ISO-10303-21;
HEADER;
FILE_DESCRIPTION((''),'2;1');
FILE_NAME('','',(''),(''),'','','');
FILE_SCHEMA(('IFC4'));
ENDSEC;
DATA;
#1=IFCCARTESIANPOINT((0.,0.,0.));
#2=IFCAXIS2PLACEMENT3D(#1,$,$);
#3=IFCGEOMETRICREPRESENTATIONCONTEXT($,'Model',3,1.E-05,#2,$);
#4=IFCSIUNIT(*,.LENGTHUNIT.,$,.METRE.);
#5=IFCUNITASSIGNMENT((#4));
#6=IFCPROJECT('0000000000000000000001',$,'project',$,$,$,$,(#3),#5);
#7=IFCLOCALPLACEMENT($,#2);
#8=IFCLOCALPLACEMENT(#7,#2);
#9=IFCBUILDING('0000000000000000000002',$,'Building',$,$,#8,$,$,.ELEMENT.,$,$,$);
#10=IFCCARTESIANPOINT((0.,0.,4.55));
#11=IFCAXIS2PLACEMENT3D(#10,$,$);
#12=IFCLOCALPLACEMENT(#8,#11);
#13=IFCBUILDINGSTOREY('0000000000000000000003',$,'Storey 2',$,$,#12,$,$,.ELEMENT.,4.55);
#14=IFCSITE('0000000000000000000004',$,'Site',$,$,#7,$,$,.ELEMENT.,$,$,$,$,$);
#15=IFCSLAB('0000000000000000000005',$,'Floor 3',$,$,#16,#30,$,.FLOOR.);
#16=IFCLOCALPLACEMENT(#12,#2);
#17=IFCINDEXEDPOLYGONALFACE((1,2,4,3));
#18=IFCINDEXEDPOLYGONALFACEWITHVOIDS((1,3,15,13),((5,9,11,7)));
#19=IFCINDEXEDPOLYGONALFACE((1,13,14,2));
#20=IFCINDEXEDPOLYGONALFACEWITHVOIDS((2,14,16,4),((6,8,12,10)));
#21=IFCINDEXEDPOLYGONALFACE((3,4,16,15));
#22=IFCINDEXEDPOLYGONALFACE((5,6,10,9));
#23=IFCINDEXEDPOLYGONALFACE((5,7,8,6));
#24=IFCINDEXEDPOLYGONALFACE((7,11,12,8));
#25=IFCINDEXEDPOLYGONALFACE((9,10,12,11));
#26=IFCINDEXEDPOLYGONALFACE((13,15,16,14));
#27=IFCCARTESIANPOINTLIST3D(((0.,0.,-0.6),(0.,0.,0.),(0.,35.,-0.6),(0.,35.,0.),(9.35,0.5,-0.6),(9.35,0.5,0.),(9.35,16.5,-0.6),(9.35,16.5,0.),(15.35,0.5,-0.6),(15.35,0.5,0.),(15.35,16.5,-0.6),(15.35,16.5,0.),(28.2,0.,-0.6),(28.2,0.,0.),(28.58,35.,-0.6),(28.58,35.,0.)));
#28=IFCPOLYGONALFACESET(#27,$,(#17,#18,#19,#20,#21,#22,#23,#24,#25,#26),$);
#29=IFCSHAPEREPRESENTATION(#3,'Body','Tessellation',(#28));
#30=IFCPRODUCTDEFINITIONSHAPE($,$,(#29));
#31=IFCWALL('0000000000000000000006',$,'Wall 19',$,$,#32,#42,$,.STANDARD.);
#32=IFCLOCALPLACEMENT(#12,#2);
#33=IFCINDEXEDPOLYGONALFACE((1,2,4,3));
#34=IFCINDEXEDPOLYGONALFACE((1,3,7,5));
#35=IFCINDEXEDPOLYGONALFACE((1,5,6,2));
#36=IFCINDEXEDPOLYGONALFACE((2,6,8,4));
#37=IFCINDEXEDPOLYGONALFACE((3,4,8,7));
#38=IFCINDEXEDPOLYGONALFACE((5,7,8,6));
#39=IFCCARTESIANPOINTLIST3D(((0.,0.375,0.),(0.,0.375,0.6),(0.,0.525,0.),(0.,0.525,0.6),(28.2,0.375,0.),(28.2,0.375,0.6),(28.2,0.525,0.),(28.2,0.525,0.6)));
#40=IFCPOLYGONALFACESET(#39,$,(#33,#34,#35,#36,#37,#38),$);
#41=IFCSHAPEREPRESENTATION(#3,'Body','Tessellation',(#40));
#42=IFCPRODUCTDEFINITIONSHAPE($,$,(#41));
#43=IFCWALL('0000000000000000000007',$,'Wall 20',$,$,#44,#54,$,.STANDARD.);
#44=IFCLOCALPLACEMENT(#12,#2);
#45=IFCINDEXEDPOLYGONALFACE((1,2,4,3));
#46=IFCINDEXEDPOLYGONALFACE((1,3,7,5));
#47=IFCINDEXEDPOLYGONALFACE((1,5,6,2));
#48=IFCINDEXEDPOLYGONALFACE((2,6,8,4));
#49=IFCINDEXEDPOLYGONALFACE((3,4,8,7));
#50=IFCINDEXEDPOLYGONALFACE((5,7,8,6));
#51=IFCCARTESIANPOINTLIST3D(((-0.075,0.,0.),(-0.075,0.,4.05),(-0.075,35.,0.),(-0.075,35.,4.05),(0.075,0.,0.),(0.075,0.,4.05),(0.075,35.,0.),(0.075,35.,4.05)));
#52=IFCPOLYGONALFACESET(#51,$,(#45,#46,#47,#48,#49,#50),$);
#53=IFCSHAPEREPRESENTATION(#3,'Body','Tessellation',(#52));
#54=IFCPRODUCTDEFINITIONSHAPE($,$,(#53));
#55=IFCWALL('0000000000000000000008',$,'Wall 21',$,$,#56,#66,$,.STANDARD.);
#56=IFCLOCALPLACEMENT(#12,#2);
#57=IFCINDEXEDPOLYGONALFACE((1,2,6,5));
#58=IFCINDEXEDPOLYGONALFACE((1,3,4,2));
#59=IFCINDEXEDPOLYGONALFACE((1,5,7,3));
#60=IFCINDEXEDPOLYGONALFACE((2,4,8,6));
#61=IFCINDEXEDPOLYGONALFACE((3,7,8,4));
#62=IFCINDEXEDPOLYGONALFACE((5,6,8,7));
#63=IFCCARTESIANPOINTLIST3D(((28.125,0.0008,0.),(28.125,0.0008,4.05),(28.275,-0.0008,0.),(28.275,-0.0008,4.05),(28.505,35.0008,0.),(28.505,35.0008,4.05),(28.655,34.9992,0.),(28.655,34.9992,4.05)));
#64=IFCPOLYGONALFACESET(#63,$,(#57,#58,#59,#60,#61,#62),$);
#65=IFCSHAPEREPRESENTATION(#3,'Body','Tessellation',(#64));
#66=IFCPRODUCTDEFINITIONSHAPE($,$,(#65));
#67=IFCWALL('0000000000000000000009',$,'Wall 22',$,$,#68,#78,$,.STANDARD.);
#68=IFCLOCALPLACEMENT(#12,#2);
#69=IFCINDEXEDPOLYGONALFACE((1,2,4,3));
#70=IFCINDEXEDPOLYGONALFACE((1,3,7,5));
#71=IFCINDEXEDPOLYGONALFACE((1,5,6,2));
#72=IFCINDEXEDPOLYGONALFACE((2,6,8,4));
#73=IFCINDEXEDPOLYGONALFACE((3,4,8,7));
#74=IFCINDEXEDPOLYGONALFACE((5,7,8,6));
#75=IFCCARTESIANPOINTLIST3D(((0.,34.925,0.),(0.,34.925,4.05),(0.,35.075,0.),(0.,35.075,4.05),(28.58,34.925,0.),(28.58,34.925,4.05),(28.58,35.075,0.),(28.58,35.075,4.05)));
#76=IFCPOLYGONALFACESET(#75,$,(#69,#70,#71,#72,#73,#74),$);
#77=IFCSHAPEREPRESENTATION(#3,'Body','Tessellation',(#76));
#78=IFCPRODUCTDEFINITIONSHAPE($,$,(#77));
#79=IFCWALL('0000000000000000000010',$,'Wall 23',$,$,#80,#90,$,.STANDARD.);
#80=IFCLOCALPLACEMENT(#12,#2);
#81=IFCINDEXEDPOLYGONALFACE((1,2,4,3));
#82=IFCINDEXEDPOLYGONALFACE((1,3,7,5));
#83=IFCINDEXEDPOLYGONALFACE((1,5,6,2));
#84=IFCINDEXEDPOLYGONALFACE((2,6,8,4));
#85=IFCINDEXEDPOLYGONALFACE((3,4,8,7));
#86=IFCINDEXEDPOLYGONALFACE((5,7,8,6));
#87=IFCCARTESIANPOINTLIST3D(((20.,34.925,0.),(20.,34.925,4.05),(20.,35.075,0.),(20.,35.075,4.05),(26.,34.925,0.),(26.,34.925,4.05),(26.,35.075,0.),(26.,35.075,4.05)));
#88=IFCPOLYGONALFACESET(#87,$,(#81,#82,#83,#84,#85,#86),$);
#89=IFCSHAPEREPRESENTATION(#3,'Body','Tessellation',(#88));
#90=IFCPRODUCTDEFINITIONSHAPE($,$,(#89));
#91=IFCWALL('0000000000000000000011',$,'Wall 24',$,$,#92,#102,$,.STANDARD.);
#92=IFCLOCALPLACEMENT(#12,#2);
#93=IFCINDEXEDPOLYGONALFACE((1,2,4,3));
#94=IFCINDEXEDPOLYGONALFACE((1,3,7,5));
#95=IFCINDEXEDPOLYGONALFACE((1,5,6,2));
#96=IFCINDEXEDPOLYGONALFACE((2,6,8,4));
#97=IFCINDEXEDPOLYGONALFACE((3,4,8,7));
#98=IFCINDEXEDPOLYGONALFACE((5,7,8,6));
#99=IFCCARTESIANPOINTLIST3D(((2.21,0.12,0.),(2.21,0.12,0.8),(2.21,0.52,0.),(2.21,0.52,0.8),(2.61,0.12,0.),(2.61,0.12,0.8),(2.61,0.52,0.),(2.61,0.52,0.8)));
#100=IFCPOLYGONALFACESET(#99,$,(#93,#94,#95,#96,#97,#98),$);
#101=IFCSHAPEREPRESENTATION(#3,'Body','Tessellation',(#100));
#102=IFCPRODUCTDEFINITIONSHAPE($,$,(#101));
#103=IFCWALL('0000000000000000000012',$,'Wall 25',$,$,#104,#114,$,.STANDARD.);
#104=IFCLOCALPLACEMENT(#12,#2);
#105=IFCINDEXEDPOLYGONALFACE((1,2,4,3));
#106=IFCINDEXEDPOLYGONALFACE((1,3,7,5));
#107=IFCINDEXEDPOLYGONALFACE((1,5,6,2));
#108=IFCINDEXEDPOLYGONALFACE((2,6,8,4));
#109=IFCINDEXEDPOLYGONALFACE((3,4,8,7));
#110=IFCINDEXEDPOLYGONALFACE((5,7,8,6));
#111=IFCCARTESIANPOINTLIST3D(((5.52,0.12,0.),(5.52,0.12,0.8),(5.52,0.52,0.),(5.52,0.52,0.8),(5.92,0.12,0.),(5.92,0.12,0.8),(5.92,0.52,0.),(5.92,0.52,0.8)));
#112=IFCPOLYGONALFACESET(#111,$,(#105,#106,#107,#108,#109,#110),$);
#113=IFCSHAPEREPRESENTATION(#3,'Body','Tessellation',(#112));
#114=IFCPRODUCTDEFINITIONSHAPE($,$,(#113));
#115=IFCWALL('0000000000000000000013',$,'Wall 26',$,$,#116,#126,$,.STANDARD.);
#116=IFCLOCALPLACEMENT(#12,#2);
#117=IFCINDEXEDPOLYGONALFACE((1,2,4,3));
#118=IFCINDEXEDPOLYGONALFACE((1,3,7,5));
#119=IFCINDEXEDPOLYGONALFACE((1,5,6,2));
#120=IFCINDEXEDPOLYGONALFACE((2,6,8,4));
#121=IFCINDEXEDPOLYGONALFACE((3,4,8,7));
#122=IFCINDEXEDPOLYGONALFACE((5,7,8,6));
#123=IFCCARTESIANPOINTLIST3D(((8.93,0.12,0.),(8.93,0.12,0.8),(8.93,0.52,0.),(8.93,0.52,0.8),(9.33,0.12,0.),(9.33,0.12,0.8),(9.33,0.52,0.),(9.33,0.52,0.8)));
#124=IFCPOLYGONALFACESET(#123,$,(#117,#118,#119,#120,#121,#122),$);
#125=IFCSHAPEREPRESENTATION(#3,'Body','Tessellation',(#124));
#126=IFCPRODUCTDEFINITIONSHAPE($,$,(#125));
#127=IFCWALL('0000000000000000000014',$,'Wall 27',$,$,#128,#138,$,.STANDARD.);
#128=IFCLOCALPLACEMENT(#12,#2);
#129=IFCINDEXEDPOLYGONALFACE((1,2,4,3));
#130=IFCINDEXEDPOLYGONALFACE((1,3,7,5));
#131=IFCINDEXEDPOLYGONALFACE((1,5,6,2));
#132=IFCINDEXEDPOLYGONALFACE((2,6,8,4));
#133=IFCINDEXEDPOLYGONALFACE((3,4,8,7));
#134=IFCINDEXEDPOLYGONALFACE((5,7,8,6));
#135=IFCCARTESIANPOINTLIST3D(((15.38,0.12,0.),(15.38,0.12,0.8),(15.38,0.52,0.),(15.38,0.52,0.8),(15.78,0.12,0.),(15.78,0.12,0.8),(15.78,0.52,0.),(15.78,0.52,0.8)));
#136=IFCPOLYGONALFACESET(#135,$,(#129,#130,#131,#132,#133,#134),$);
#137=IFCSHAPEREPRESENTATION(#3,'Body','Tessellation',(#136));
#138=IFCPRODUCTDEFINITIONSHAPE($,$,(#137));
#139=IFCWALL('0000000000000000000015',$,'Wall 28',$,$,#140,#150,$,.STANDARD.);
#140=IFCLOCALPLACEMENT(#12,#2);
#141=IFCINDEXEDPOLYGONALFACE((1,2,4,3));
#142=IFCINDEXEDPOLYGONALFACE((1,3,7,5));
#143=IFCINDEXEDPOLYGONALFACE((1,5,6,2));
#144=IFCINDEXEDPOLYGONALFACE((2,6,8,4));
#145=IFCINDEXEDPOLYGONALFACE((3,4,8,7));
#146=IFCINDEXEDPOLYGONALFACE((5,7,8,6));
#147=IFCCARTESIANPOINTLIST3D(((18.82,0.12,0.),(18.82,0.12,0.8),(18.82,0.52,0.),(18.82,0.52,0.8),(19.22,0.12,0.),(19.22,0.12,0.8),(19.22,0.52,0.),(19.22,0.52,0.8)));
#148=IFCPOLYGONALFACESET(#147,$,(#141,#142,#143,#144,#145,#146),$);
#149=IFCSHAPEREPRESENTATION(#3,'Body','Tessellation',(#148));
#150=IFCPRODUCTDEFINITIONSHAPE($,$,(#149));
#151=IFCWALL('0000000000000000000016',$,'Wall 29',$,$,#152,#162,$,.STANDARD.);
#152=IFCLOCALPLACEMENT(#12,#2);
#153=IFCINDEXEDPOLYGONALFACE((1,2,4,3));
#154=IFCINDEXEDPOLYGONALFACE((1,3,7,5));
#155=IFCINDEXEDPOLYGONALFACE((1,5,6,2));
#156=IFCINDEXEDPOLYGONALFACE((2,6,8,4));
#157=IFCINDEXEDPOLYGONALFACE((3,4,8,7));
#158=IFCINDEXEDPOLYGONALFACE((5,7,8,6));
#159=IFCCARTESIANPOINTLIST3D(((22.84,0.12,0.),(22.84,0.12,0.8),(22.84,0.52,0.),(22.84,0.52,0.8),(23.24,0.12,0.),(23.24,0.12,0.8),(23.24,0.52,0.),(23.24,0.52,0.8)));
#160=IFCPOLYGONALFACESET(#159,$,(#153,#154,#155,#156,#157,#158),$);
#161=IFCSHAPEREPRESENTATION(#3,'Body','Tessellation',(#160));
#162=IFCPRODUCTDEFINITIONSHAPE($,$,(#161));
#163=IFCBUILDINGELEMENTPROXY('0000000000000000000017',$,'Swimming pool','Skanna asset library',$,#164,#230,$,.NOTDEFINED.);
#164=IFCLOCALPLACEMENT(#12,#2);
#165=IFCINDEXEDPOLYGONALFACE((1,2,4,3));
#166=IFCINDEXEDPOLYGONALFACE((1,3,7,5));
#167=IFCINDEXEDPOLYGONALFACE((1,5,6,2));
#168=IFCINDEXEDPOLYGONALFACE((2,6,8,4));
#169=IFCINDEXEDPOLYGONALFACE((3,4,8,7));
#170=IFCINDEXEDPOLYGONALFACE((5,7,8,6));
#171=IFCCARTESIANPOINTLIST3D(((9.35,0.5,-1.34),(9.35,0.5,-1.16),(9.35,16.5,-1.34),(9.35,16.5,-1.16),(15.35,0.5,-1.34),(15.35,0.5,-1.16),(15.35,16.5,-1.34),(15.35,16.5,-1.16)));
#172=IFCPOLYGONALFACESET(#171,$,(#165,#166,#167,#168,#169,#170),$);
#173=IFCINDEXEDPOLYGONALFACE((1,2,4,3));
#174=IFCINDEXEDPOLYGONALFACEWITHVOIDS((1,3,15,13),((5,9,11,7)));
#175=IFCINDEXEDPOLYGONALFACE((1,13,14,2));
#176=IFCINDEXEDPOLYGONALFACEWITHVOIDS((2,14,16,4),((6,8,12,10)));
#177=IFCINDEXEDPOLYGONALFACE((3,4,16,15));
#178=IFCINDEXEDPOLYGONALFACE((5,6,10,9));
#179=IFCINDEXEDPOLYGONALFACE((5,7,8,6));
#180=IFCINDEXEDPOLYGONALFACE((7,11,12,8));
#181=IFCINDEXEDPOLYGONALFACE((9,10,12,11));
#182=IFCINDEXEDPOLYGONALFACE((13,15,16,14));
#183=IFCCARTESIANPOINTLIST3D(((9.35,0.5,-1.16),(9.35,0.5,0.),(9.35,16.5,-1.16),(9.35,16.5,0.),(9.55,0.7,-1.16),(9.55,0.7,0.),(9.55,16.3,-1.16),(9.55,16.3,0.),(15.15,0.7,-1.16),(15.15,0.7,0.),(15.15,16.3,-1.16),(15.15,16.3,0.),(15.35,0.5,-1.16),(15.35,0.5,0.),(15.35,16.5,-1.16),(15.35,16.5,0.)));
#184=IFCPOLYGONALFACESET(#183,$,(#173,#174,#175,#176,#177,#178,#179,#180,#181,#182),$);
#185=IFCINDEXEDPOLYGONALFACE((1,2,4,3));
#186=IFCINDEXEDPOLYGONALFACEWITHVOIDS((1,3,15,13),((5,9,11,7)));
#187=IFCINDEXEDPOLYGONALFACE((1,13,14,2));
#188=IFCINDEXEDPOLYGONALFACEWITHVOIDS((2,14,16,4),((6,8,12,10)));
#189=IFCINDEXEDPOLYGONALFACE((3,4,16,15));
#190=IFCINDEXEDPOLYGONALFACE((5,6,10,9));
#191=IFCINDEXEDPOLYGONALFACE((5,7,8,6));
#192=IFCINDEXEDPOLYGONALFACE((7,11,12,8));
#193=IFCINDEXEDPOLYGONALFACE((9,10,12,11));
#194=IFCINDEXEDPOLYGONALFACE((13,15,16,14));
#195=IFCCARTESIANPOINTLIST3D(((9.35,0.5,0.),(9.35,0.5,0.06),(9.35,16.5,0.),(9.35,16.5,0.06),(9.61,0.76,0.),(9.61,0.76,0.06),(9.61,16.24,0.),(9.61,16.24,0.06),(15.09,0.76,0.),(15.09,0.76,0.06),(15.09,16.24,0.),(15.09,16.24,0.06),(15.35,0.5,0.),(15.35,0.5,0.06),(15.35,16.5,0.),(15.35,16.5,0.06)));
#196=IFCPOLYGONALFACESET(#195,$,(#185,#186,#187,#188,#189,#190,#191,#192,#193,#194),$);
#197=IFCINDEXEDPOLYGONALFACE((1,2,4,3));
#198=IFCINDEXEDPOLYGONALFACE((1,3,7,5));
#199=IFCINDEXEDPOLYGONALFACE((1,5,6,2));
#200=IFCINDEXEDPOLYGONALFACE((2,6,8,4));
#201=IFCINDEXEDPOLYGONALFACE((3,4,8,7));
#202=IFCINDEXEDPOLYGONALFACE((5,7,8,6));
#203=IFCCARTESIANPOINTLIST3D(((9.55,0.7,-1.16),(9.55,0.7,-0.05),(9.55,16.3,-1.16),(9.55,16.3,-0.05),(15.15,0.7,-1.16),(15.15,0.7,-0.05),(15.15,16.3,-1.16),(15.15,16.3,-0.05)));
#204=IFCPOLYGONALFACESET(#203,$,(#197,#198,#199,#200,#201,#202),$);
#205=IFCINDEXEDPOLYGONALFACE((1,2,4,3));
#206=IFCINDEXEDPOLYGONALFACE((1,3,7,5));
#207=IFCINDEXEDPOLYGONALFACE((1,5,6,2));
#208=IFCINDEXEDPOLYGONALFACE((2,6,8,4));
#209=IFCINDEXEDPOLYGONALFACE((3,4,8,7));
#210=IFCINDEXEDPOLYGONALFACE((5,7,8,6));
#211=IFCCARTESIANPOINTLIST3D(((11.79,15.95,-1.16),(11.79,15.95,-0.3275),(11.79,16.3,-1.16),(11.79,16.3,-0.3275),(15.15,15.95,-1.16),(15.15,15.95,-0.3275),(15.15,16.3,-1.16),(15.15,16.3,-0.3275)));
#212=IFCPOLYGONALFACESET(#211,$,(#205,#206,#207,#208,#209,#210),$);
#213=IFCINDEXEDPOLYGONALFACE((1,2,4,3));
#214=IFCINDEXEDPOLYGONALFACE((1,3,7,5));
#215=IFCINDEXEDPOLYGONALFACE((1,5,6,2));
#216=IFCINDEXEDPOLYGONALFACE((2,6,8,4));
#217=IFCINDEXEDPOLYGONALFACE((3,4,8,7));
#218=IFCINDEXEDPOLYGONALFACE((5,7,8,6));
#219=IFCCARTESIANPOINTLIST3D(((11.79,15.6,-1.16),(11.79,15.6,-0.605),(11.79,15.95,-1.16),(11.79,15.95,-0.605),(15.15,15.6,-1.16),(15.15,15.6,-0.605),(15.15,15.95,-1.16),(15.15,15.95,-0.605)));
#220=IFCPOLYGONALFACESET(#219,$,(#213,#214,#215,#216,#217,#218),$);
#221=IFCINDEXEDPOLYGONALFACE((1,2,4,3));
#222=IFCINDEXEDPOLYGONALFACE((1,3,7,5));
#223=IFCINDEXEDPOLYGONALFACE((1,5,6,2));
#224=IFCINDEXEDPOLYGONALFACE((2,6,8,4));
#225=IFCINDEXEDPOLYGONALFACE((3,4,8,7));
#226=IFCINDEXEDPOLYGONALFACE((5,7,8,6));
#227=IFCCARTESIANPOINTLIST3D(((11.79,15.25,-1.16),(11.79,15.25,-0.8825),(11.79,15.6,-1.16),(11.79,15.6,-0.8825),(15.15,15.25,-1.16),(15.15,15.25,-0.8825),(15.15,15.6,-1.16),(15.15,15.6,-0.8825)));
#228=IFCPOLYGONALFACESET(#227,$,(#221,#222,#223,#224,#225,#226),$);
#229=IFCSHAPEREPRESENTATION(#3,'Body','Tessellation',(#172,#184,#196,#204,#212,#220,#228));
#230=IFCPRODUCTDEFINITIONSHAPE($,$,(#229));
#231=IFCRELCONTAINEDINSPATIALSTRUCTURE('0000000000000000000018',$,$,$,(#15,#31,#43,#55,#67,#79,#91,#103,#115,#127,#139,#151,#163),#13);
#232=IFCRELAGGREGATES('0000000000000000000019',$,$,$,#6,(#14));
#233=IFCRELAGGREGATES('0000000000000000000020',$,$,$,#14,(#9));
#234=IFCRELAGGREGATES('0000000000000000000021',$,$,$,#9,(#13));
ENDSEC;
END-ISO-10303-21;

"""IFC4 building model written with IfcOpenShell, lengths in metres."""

from ifc_helpers import new_model, si_unit, frame, frame_2d, origin, origin_2d, place, context, project, spatial, polyline, rectangle, outline, extrude, element, save


model = new_model("IFC4")

# Units and contexts
model_context = context("Model", 3, precision=1e-05, world=origin())
ifc_project = project(units=[si_unit("LENGTHUNIT", "METRE")], contexts=[model_context])

# Site, building, storey
site_placement = place(None, origin())
site = spatial("IfcSite", under=ifc_project, at=site_placement, Name="Site", CompositionType="ELEMENT")
building_placement = place(site_placement, origin())
building = spatial("IfcBuilding", under=site, at=building_placement, Name="Building", CompositionType="ELEMENT")
storey_placement = place(building_placement, frame((0.0, 0.0, 4.55)))
storey = spatial("IfcBuildingStorey", under=building, at=storey_placement, Name="Storey 2", CompositionType="ELEMENT", Elevation=4.55)

# Slab
slab_placement = place(storey_placement, frame((0.0, 0.0, -0.6), z_axis=(0.0, 0.0, 1.0), x_axis=(1.0, 0.0, 0.0)))
element("IfcSlab", 1, at=slab_placement, inside=storey, Name="Floor 3", PredefinedType="FLOOR", context=model_context, shape_type="SweptSolid", body=[
    extrude(outline(polyline([(0.0, 0.0), (0.0, 35.0), (28.58, 35.0), (28.2, 0.0), (0.0, 0.0)]), holes=[polyline([(9.35, 0.5), (15.35, 0.5), (15.35, 16.5), (9.35, 16.5), (9.35, 0.5)])]), origin(), (0.0, 0.0, 1.0), 0.6),
])

# Walls
wall_1_placement = place(storey_placement, frame((0.0, 0.45, 0.0), z_axis=(0.0, 0.0, 1.0), x_axis=(1.0, 0.0, 0.0)))
element("IfcWall", 2, at=wall_1_placement, inside=storey, Name="Wall 19", PredefinedType="STANDARD", context=model_context, shape_type="SweptSolid", body=[
    extrude(rectangle(XDim=28.2, YDim=0.15, at=frame_2d((14.1, 0.0))), origin(), (0.0, 0.0, 1.0), 0.6),
])
wall_2_placement = place(storey_placement, frame((0.0, 0.0, 0.0), z_axis=(0.0, 0.0, 1.0), x_axis=(0.0, 1.0, 0.0)))
element("IfcWall", 3, at=wall_2_placement, inside=storey, Name="Wall 20", PredefinedType="STANDARD", context=model_context, shape_type="SweptSolid", body=[
    extrude(rectangle(XDim=35.0, YDim=0.15, at=frame_2d((17.5, 0.0))), origin(), (0.0, 0.0, 1.0), 4.05),
])
wall_3_placement = place(storey_placement, frame((28.2, 0.0, 0.0), z_axis=(0.0, 0.0, 1.0), x_axis=(0.010857, 0.999941, 0.0)))
element("IfcWall", 4, at=wall_3_placement, inside=storey, Name="Wall 21", PredefinedType="STANDARD", context=model_context, shape_type="SweptSolid", body=[
    extrude(rectangle(XDim=35.0021, YDim=0.15, at=frame_2d((17.501, 0.0))), origin(), (0.0, 0.0, 1.0), 4.05),
])
wall_4_placement = place(storey_placement, frame((0.0, 35.0, 0.0), z_axis=(0.0, 0.0, 1.0), x_axis=(1.0, 0.0, 0.0)))
element("IfcWall", 5, at=wall_4_placement, inside=storey, Name="Wall 22", PredefinedType="STANDARD", context=model_context, shape_type="SweptSolid", body=[
    extrude(rectangle(XDim=28.58, YDim=0.15, at=frame_2d((14.29, 0.0))), origin(), (0.0, 0.0, 1.0), 4.05),
])
wall_5_placement = place(storey_placement, frame((26.0, 35.0, 0.0), z_axis=(0.0, 0.0, 1.0), x_axis=(-1.0, 0.0, 0.0)))
element("IfcWall", 6, at=wall_5_placement, inside=storey, Name="Wall 23", PredefinedType="STANDARD", context=model_context, shape_type="SweptSolid", body=[
    extrude(rectangle(XDim=6.0, YDim=0.15, at=frame_2d((3.0, 0.0))), origin(), (0.0, 0.0, 1.0), 4.05),
])
for number, where, z_axis, x_axis, name in (
    (7, (2.21, 0.32, 0.0), (0.0, 0.0, 1.0), (1.0, 0.0, 0.0), "Wall 24"),
    (8, (5.52, 0.32, 0.0), (0.0, 0.0, 1.0), (1.0, 0.0, 0.0), "Wall 25"),
    (9, (8.93, 0.32, 0.0), (0.0, 0.0, 1.0), (1.0, 0.0, 0.0), "Wall 26"),
    (10, (15.38, 0.32, 0.0), (0.0, 0.0, 1.0), (1.0, 0.0, 0.0), "Wall 27"),
    (11, (18.82, 0.32, 0.0), (0.0, 0.0, 1.0), (1.0, 0.0, 0.0), "Wall 28"),
    (12, (22.84, 0.32, 0.0), (0.0, 0.0, 1.0), (1.0, 0.0, 0.0), "Wall 29"),
):
    element("IfcWall", number, at=place(storey_placement, frame(where, z_axis=z_axis, x_axis=x_axis)), inside=storey, Name=name, PredefinedType="STANDARD", context=model_context, shape_type="SweptSolid", body=[
        extrude(rectangle(XDim=0.4, YDim=0.4, at=frame_2d((0.2, 0.0))), origin(), (0.0, 0.0, 1.0), 0.8),
    ])

# Building element proxy
proxy_placement = place(storey_placement, frame((12.35, 8.5, -1.34), z_axis=(0.0, 0.0, 1.0), x_axis=(-1.0, 0.0, 0.0)))
element("IfcBuildingElementProxy", 13, at=proxy_placement, inside=storey, Name="Swimming pool", Description="Skanna asset library", PredefinedType="NOTDEFINED", context=model_context, shape_type="SweptSolid", body=[
    extrude(rectangle(XDim=6.0, YDim=16.0, at=origin_2d()), origin(), (0.0, 0.0, 1.0), 0.18),
    extrude(outline(polyline([(-3.0, -8.0), (3.0, -8.0), (3.0, 8.0), (-3.0, 8.0), (-3.0, -8.0)]), holes=[polyline([(-2.8, -7.8), (2.8, -7.8), (2.8, 7.8), (-2.8, 7.8), (-2.8, -7.8)])]), frame((0.0, 0.0, 0.18)), (0.0, 0.0, 1.0), 1.16),
    extrude(outline(polyline([(-3.0, -8.0), (3.0, -8.0), (3.0, 8.0), (-3.0, 8.0), (-3.0, -8.0)]), holes=[polyline([(-2.74, -7.74), (2.74, -7.74), (2.74, 7.74), (-2.74, 7.74), (-2.74, -7.74)])]), frame((0.0, 0.0, 1.34)), (0.0, 0.0, 1.0), 0.06),
    extrude(rectangle(XDim=5.6, YDim=15.6, at=origin_2d()), frame((0.0, 0.0, 0.18)), (0.0, 0.0, 1.0), 1.11),
    extrude(rectangle(XDim=3.36, YDim=0.35, at=frame_2d((-1.12, -7.625))), frame((0.0, 0.0, 0.18)), (0.0, 0.0, 1.0), 0.8325),
    extrude(rectangle(XDim=3.36, YDim=0.35, at=frame_2d((-1.12, -7.275))), frame((0.0, 0.0, 0.18)), (0.0, 0.0, 1.0), 0.555),
    extrude(rectangle(XDim=3.36, YDim=0.35, at=frame_2d((-1.12, -6.925))), frame((0.0, 0.0, 0.18)), (0.0, 0.0, 1.0), 0.2775),
])

save(model, "model.ifc")
